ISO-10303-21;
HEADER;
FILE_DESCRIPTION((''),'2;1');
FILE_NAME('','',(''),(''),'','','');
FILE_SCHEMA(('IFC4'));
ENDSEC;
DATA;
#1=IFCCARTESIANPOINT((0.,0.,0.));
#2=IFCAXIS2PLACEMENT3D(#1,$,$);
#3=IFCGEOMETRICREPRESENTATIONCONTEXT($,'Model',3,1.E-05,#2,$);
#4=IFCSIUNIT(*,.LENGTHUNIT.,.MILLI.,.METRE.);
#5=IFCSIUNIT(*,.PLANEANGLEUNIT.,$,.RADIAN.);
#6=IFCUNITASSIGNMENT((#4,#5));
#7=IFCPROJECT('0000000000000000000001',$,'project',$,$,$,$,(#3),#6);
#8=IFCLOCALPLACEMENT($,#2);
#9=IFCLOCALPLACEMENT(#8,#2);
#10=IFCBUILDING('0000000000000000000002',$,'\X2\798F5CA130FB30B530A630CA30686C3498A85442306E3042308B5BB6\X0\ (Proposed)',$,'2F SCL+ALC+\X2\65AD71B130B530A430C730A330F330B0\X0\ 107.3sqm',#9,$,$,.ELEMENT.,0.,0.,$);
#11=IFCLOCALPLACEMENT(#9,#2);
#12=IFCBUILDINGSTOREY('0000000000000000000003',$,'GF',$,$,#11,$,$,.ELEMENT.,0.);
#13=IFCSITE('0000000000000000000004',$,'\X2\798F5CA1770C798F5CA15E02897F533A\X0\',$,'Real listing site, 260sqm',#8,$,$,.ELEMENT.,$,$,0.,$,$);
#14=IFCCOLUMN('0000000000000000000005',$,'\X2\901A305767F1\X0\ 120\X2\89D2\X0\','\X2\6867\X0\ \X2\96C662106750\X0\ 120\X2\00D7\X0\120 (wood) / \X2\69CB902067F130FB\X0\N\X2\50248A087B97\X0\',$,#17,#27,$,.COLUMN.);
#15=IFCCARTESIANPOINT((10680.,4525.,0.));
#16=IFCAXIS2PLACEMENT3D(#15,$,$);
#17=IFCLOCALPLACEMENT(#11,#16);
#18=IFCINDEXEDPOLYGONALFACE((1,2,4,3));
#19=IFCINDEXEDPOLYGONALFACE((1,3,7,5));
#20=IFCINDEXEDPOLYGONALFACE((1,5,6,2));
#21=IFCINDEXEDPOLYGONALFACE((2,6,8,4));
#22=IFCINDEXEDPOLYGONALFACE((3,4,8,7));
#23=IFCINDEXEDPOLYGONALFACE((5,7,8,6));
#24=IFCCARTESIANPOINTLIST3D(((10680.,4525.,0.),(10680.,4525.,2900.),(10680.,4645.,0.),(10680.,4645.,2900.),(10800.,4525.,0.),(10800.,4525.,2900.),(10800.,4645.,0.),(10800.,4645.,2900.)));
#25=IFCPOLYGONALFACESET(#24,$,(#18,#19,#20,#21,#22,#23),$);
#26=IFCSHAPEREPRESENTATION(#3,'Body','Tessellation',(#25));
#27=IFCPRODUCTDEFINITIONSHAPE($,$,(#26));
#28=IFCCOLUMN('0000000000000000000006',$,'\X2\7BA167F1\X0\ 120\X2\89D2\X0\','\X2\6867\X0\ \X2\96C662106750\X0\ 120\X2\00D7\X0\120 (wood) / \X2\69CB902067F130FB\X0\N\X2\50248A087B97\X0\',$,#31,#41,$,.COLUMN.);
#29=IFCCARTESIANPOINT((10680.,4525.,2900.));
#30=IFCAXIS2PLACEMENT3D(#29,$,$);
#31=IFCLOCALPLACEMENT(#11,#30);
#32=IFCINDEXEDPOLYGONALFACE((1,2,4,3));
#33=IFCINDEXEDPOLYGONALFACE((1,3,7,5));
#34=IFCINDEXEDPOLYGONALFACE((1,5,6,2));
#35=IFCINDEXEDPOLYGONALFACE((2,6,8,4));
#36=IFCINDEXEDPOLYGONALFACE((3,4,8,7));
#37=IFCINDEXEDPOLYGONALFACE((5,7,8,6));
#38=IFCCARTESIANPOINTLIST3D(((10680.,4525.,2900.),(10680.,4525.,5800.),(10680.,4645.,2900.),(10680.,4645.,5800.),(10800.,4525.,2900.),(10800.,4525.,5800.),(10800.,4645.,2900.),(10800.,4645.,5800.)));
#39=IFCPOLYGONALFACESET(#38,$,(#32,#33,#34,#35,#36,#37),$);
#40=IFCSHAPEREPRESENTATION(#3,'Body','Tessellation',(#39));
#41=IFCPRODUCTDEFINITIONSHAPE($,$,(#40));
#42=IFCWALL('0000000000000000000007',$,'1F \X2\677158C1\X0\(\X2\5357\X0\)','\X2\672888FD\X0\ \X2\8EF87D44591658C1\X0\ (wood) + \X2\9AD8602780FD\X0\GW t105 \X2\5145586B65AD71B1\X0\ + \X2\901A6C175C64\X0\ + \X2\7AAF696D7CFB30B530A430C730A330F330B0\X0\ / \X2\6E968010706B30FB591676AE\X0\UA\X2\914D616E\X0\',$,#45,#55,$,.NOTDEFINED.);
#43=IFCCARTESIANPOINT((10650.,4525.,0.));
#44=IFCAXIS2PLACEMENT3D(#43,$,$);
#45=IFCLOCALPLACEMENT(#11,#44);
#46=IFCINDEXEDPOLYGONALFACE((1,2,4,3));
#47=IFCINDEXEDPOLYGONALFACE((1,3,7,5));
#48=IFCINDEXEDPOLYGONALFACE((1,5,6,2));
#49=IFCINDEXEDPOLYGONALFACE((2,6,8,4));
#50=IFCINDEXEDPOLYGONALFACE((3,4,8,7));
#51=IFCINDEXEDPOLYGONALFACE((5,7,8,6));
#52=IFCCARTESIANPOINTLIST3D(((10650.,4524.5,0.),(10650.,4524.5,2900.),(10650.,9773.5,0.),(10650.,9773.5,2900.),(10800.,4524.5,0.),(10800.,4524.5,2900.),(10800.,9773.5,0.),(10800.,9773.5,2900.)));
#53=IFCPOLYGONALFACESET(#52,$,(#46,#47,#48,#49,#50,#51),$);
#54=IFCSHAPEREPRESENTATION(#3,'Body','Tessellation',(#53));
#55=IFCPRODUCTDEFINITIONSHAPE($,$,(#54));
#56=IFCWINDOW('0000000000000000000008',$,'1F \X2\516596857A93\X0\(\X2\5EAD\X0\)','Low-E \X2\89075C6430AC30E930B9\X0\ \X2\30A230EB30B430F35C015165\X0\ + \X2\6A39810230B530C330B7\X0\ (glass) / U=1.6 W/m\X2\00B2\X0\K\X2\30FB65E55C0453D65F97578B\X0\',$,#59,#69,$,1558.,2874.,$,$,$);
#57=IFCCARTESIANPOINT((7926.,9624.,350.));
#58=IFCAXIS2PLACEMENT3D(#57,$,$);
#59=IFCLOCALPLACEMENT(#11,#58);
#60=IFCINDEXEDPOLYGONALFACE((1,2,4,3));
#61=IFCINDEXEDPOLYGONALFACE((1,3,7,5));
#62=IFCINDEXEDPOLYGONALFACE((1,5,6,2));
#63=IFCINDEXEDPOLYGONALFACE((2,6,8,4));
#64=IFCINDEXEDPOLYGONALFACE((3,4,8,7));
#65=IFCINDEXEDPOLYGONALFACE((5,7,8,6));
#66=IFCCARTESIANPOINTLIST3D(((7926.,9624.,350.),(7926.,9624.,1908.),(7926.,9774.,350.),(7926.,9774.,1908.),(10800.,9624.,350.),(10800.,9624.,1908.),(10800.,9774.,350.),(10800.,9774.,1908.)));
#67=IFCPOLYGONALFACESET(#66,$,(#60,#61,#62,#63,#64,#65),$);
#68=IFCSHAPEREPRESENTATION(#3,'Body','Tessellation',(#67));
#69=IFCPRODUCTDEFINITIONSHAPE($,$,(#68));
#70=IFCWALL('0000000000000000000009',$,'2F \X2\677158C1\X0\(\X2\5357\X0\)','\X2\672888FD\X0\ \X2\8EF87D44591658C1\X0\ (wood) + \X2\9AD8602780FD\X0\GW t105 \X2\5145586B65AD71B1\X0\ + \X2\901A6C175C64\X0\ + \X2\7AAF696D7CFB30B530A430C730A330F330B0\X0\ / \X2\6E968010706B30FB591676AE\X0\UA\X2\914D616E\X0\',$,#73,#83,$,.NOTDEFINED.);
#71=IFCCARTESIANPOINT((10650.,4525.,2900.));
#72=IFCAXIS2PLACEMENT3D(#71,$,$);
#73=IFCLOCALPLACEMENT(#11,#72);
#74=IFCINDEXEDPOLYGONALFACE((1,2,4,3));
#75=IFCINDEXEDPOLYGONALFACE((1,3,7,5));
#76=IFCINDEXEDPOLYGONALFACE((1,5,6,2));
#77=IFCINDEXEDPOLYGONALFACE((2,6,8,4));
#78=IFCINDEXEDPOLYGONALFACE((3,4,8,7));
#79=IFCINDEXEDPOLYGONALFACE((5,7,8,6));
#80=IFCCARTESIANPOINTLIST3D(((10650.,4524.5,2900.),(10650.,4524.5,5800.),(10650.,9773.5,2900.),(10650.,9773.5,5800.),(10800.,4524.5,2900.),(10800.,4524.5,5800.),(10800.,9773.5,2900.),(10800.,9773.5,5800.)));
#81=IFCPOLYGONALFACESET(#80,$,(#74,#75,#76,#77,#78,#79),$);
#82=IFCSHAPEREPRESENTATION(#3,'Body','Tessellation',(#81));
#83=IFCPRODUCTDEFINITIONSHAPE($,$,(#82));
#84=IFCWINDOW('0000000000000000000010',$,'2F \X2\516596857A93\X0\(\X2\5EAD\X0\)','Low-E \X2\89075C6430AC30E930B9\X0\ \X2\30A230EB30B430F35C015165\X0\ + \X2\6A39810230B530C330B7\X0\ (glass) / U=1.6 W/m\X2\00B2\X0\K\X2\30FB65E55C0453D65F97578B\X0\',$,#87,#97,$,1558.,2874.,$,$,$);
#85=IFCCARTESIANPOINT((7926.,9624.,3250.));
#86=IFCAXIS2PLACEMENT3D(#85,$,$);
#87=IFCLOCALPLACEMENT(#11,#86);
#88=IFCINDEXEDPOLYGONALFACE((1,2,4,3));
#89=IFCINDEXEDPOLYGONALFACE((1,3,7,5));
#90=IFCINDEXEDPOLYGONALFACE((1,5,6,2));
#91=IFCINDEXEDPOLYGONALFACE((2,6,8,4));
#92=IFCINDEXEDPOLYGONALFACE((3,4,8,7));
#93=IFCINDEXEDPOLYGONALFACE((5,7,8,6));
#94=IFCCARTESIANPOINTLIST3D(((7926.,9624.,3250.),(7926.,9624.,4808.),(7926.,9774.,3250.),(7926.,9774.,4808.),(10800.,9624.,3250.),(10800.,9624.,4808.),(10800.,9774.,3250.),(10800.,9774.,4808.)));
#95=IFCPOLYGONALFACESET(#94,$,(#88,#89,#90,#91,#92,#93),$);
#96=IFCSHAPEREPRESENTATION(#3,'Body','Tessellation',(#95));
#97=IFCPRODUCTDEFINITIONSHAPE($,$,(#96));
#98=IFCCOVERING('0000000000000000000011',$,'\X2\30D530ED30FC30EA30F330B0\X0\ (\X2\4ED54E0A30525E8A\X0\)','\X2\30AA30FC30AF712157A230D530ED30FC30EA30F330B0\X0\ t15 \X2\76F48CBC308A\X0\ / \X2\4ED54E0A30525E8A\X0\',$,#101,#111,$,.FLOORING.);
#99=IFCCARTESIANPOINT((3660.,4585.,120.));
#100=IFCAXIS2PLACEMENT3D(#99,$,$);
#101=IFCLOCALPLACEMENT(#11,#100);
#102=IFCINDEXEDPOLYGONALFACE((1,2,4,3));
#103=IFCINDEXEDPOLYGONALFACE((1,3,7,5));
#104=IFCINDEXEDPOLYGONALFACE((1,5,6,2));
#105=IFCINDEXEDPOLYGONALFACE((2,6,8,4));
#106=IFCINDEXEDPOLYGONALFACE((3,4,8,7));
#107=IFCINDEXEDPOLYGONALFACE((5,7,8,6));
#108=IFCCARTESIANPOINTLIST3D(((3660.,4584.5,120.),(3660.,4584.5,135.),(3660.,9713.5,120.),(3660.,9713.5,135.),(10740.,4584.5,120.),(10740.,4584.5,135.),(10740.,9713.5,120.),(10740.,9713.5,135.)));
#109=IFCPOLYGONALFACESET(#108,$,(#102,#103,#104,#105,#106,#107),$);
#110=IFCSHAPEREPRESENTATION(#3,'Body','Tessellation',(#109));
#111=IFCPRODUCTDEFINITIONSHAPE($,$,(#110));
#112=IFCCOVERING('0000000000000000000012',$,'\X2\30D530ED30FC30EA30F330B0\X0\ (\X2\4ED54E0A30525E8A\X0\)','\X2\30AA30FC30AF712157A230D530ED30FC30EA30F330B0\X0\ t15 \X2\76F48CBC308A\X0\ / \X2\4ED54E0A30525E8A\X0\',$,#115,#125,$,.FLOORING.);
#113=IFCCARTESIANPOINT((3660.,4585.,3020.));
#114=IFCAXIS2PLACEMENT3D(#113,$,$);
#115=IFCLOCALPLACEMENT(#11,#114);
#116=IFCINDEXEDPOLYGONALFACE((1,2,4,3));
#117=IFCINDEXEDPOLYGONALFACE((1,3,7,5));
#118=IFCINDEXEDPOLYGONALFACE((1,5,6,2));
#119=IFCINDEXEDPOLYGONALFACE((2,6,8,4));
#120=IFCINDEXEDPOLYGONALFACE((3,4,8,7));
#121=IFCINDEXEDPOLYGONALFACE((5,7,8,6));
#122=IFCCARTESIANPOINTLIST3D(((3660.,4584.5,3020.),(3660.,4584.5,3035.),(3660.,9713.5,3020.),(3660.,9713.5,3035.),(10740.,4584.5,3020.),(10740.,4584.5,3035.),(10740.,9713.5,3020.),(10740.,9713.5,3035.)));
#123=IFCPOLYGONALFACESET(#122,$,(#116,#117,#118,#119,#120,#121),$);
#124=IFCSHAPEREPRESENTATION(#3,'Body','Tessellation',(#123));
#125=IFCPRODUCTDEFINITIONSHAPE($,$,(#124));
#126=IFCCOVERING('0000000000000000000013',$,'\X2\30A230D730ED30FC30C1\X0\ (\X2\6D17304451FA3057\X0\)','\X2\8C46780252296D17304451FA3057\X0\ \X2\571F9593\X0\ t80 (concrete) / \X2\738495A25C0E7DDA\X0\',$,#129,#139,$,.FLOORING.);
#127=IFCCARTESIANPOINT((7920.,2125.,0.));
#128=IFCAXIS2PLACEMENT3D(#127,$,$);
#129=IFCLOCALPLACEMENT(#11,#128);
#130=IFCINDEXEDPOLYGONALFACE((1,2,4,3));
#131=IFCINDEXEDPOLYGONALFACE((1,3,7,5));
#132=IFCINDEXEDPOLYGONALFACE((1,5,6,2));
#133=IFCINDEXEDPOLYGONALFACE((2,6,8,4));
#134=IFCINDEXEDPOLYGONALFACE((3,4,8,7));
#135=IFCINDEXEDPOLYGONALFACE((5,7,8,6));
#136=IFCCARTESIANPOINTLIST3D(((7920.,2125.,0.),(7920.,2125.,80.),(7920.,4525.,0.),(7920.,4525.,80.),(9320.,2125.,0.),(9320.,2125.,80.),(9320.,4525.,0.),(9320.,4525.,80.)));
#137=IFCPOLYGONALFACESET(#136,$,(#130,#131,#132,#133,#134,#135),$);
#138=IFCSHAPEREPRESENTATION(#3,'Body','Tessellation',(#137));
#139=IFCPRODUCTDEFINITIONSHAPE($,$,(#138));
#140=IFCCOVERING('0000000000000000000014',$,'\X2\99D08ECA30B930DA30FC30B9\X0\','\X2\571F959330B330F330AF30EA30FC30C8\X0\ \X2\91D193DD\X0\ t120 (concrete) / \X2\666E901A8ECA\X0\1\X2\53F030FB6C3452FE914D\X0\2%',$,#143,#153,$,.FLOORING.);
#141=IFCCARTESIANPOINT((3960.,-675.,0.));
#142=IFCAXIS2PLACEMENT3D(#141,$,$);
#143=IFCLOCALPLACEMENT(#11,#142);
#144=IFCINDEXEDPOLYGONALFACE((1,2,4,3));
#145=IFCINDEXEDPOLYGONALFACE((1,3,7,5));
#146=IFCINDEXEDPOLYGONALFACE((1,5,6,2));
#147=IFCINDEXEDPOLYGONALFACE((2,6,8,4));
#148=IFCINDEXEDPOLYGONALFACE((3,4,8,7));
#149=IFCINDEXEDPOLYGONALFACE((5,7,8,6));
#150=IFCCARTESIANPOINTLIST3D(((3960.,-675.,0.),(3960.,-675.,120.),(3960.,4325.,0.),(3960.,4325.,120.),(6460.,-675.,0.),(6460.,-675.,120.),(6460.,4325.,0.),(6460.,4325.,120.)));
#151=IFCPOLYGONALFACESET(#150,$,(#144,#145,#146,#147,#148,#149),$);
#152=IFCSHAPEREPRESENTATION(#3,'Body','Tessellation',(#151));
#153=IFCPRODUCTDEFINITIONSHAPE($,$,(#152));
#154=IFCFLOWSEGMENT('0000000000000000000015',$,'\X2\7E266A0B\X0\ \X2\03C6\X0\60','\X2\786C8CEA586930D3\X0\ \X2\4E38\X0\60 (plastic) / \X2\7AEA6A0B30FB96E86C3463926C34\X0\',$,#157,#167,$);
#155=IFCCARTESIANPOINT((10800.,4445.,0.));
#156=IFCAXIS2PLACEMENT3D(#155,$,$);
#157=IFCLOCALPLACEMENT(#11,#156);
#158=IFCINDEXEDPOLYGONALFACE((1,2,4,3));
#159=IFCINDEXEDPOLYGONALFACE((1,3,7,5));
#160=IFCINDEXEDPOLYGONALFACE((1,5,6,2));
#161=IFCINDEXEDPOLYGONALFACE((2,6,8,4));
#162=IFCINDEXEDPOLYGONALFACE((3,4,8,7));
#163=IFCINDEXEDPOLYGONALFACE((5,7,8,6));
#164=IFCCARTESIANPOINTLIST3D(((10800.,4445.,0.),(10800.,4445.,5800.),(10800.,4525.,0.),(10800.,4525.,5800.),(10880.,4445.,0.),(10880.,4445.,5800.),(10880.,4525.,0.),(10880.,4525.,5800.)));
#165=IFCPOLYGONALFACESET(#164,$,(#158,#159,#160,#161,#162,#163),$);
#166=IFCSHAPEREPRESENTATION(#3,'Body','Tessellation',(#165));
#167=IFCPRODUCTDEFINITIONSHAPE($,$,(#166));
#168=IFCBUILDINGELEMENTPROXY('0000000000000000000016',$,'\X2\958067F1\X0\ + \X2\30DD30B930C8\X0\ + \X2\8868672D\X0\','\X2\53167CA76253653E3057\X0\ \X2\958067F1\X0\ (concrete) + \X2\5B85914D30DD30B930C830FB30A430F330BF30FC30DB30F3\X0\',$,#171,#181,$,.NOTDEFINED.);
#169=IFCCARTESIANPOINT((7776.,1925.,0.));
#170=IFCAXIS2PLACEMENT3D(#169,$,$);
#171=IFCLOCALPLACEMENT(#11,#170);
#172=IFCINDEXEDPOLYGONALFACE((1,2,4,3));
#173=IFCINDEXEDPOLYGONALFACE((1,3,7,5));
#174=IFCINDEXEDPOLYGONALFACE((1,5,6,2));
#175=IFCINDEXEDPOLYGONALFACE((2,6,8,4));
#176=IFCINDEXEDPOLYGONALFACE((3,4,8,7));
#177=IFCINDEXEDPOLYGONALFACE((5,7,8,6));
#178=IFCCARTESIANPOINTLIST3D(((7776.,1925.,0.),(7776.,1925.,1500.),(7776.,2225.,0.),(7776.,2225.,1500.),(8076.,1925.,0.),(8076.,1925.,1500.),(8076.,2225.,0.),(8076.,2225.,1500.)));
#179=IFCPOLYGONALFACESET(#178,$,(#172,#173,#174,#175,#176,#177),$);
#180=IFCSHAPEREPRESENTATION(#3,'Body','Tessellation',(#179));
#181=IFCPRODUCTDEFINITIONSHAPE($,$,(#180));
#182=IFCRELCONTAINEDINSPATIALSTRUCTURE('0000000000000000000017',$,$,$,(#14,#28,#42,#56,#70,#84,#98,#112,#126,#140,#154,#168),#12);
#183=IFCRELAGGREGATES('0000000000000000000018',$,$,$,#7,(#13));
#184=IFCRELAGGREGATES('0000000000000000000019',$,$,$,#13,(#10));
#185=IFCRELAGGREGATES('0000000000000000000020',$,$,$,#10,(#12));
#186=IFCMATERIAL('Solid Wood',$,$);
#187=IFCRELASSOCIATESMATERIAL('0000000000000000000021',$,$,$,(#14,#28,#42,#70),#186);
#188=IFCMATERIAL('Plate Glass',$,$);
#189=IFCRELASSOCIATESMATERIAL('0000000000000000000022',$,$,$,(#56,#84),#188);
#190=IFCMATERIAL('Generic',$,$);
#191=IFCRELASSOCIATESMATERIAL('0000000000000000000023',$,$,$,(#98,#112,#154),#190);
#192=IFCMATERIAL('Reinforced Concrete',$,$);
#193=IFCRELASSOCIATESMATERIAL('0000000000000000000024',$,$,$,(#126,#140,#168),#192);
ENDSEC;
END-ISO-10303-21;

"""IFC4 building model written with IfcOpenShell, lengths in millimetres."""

from ifc_helpers import new_model, si_unit, frame, frame_2d, origin, place, context, project, spatial, rectangle, extrude, material, element, fill, save


model = new_model("IFC4")

# Units and contexts
model_context = context("Model", 3, precision=1e-05, world=origin())
ifc_project = project(units=[si_unit("LENGTHUNIT", "METRE", prefix="MILLI"), si_unit("PLANEANGLEUNIT", "RADIAN")], contexts=[model_context])

# Site, building, storey
site_placement = place(None, origin())
site = spatial("IfcSite", under=ifc_project, at=site_placement, Name="福岡県福岡市西区", ObjectType="Real listing site, 260sqm", CompositionType="ELEMENT", RefElevation=0.0)
building_placement = place(site_placement, origin())
building = spatial("IfcBuilding", under=site, at=building_placement, Name="福岡・サウナと水風呂のある家 (Proposed)", ObjectType="2F SCL+ALC+断熱サイディング 107.3sqm", CompositionType="ELEMENT", ElevationOfRefHeight=0.0, ElevationOfTerrain=0.0)
storey_placement = place(building_placement, origin())
storey = spatial("IfcBuildingStorey", under=building, at=storey_placement, Name="GF", CompositionType="ELEMENT", Elevation=0.0)

# Columns
ifc_material_1 = material(Name="Solid Wood")
column_1_placement = place(storey_placement, frame((10680.0, 4525.0, 0.0)))
element("IfcColumn", 1, at=column_1_placement, inside=storey, material=ifc_material_1, Name="通し柱 120角", Description="桧 集成材 120×120 (wood) / 構造柱・N値計算", PredefinedType="COLUMN", context=model_context, shape_type="SweptSolid", body=[
    extrude(rectangle(XDim=120.0, YDim=120.0, at=frame_2d((60.0, 60.0))), frame((10680.0, 4525.0, 0.0)), (0.0, 0.0, 1.0), 2900.0),
])
column_2_placement = place(storey_placement, frame((10680.0, 4525.0, 2900.0)))
element("IfcColumn", 2, at=column_2_placement, inside=storey, material=ifc_material_1, Name="管柱 120角", Description="桧 集成材 120×120 (wood) / 構造柱・N値計算", PredefinedType="COLUMN", context=model_context, shape_type="SweptSolid", body=[
    extrude(rectangle(XDim=120.0, YDim=120.0, at=frame_2d((60.0, 60.0))), frame((10680.0, 4525.0, 2900.0)), (0.0, 0.0, 1.0), 2900.0),
])

# Wall, opening, window
wall_1_placement = place(storey_placement, frame((10650.0, 4525.0, 0.0)))
wall_1 = element("IfcWall", 3, at=wall_1_placement, inside=storey, material=ifc_material_1, Name="1F 東壁(南)", Description="木製 軸組外壁 (wood) + 高性能GW t105 充填断熱 + 通気層 + 窯業系サイディング / 準耐火・外皮UA配慮", PredefinedType="NOTDEFINED", context=model_context, shape_type="SweptSolid", body=[
    extrude(rectangle(XDim=150.0, YDim=5249.0, at=frame_2d((75.0, 2624.0))), frame((10650.0, 4525.0, 0.0)), (0.0, 0.0, 1.0), 2900.0),
])
opening_1_placement = place(storey_placement, frame((7926.0, 9624.0, 350.0)))
opening_1 = element("IfcOpeningElement", 4, at=opening_1_placement, cuts=wall_1, PredefinedType="NOTDEFINED", context=model_context, shape_type="SweptSolid", body=[
    extrude(rectangle(XDim=2874.0, YDim=150.0, at=frame_2d((1437.0, 75.0))), frame((7926.0, 9624.0, 350.0)), (0.0, 0.0, 1.0), 1558.0),
])
ifc_material_2 = material(Name="Plate Glass")
window_1_placement = place(storey_placement, frame((7926.0, 9624.0, 350.0)))
window_1 = element("IfcWindow", 5, at=window_1_placement, inside=storey, material=ifc_material_2, Name="1F 入隅窓(庭)", Description="Low-E 複層ガラス アルゴン封入 + 樹脂サッシ (glass) / U=1.6 W/m²K・日射取得型", OverallHeight=1558.0, OverallWidth=2874.0, context=model_context, shape_type="SweptSolid", body=[
    extrude(rectangle(XDim=2874.0, YDim=150.0, at=frame_2d((1437.0, 75.0))), frame((7926.0, 9624.0, 350.0)), (0.0, 0.0, 1.0), 1558.0),
])
fill(opening_1, window_1)

# Wall, opening, window
wall_2_placement = place(storey_placement, frame((10650.0, 4525.0, 2900.0)))
wall_2 = element("IfcWall", 6, at=wall_2_placement, inside=storey, material=ifc_material_1, Name="2F 東壁(南)", Description="木製 軸組外壁 (wood) + 高性能GW t105 充填断熱 + 通気層 + 窯業系サイディング / 準耐火・外皮UA配慮", PredefinedType="NOTDEFINED", context=model_context, shape_type="SweptSolid", body=[
    extrude(rectangle(XDim=150.0, YDim=5249.0, at=frame_2d((75.0, 2624.0))), frame((10650.0, 4525.0, 2900.0)), (0.0, 0.0, 1.0), 2900.0),
])
opening_2_placement = place(storey_placement, frame((7926.0, 9624.0, 3250.0)))
opening_2 = element("IfcOpeningElement", 7, at=opening_2_placement, cuts=wall_2, PredefinedType="NOTDEFINED", context=model_context, shape_type="SweptSolid", body=[
    extrude(rectangle(XDim=2874.0, YDim=150.0, at=frame_2d((1437.0, 75.0))), frame((7926.0, 9624.0, 3250.0)), (0.0, 0.0, 1.0), 1558.0),
])
window_2_placement = place(storey_placement, frame((7926.0, 9624.0, 3250.0)))
window_2 = element("IfcWindow", 8, at=window_2_placement, inside=storey, material=ifc_material_2, Name="2F 入隅窓(庭)", Description="Low-E 複層ガラス アルゴン封入 + 樹脂サッシ (glass) / U=1.6 W/m²K・日射取得型", OverallHeight=1558.0, OverallWidth=2874.0, context=model_context, shape_type="SweptSolid", body=[
    extrude(rectangle(XDim=2874.0, YDim=150.0, at=frame_2d((1437.0, 75.0))), frame((7926.0, 9624.0, 3250.0)), (0.0, 0.0, 1.0), 1558.0),
])
fill(opening_2, window_2)

# Coverings
ifc_material_3 = material(Name="Generic")
covering_1_placement = place(storey_placement, frame((3660.0, 4585.0, 120.0)))
element("IfcCovering", 9, at=covering_1_placement, inside=storey, material=ifc_material_3, Name="フローリング (仕上げ床)", Description="オーク無垢フローリング t15 直貼り / 仕上げ床", PredefinedType="FLOORING", context=model_context, shape_type="SweptSolid", body=[
    extrude(rectangle(XDim=7080.0, YDim=5129.0, at=frame_2d((3540.0, 2564.0))), frame((3660.0, 4585.0, 120.0)), (0.0, 0.0, 1.0), 15.0),
])
covering_2_placement = place(storey_placement, frame((3660.0, 4585.0, 3020.0)))
element("IfcCovering", 10, at=covering_2_placement, inside=storey, material=ifc_material_3, Name="フローリング (仕上げ床)", Description="オーク無垢フローリング t15 直貼り / 仕上げ床", PredefinedType="FLOORING", context=model_context, shape_type="SweptSolid", body=[
    extrude(rectangle(XDim=7080.0, YDim=5129.0, at=frame_2d((3540.0, 2564.0))), frame((3660.0, 4585.0, 3020.0)), (0.0, 0.0, 1.0), 15.0),
])
ifc_material_4 = material(Name="Reinforced Concrete")
covering_3_placement = place(storey_placement, frame((7920.0, 2125.0, 0.0)))
element("IfcCovering", 11, at=covering_3_placement, inside=storey, material=ifc_material_4, Name="アプローチ (洗い出し)", Description="豆砂利洗い出し 土間 t80 (concrete) / 玄関導線", PredefinedType="FLOORING", context=model_context, shape_type="SweptSolid", body=[
    extrude(rectangle(XDim=1400.0, YDim=2400.0, at=frame_2d((700.0, 1200.0))), frame((7920.0, 2125.0, 0.0)), (0.0, 0.0, 1.0), 80.0),
])
covering_4_placement = place(storey_placement, frame((3960.0, -675.0, 0.0)))
element("IfcCovering", 12, at=covering_4_placement, inside=storey, material=ifc_material_4, Name="駐車スペース", Description="土間コンクリート 金鏝 t120 (concrete) / 普通車1台・水勾配2%", PredefinedType="FLOORING", context=model_context, shape_type="SweptSolid", body=[
    extrude(rectangle(XDim=2500.0, YDim=5000.0, at=frame_2d((1250.0, 2500.0))), frame((3960.0, -675.0, 0.0)), (0.0, 0.0, 1.0), 120.0),
])

# Flow segment
flow_segment_placement = place(storey_placement, frame((10800.0, 4445.0, 0.0)))
element("IfcFlowSegment", 13, at=flow_segment_placement, inside=storey, material=ifc_material_3, Name="縦樋 φ60", Description="硬質塩ビ 丸60 (plastic) / 竪樋・雨水排水", context=model_context, shape_type="SweptSolid", body=[
    extrude(rectangle(XDim=80.0, YDim=80.0, at=frame_2d((40.0, 40.0))), frame((10800.0, 4445.0, 0.0)), (0.0, 0.0, 1.0), 5800.0),
])

# Building element proxy
proxy_placement = place(storey_placement, frame((7776.0, 1925.0, 0.0)))
element("IfcBuildingElementProxy", 14, at=proxy_placement, inside=storey, material=ifc_material_4, Name="門柱 + ポスト + 表札", Description="化粧打放し 門柱 (concrete) + 宅配ポスト・インターホン", PredefinedType="NOTDEFINED", context=model_context, shape_type="SweptSolid", body=[
    extrude(rectangle(XDim=300.0, YDim=300.0, at=frame_2d((150.0, 150.0))), frame((7776.0, 1925.0, 0.0)), (0.0, 0.0, 1.0), 1500.0),
])

save(model, "model.ifc")
